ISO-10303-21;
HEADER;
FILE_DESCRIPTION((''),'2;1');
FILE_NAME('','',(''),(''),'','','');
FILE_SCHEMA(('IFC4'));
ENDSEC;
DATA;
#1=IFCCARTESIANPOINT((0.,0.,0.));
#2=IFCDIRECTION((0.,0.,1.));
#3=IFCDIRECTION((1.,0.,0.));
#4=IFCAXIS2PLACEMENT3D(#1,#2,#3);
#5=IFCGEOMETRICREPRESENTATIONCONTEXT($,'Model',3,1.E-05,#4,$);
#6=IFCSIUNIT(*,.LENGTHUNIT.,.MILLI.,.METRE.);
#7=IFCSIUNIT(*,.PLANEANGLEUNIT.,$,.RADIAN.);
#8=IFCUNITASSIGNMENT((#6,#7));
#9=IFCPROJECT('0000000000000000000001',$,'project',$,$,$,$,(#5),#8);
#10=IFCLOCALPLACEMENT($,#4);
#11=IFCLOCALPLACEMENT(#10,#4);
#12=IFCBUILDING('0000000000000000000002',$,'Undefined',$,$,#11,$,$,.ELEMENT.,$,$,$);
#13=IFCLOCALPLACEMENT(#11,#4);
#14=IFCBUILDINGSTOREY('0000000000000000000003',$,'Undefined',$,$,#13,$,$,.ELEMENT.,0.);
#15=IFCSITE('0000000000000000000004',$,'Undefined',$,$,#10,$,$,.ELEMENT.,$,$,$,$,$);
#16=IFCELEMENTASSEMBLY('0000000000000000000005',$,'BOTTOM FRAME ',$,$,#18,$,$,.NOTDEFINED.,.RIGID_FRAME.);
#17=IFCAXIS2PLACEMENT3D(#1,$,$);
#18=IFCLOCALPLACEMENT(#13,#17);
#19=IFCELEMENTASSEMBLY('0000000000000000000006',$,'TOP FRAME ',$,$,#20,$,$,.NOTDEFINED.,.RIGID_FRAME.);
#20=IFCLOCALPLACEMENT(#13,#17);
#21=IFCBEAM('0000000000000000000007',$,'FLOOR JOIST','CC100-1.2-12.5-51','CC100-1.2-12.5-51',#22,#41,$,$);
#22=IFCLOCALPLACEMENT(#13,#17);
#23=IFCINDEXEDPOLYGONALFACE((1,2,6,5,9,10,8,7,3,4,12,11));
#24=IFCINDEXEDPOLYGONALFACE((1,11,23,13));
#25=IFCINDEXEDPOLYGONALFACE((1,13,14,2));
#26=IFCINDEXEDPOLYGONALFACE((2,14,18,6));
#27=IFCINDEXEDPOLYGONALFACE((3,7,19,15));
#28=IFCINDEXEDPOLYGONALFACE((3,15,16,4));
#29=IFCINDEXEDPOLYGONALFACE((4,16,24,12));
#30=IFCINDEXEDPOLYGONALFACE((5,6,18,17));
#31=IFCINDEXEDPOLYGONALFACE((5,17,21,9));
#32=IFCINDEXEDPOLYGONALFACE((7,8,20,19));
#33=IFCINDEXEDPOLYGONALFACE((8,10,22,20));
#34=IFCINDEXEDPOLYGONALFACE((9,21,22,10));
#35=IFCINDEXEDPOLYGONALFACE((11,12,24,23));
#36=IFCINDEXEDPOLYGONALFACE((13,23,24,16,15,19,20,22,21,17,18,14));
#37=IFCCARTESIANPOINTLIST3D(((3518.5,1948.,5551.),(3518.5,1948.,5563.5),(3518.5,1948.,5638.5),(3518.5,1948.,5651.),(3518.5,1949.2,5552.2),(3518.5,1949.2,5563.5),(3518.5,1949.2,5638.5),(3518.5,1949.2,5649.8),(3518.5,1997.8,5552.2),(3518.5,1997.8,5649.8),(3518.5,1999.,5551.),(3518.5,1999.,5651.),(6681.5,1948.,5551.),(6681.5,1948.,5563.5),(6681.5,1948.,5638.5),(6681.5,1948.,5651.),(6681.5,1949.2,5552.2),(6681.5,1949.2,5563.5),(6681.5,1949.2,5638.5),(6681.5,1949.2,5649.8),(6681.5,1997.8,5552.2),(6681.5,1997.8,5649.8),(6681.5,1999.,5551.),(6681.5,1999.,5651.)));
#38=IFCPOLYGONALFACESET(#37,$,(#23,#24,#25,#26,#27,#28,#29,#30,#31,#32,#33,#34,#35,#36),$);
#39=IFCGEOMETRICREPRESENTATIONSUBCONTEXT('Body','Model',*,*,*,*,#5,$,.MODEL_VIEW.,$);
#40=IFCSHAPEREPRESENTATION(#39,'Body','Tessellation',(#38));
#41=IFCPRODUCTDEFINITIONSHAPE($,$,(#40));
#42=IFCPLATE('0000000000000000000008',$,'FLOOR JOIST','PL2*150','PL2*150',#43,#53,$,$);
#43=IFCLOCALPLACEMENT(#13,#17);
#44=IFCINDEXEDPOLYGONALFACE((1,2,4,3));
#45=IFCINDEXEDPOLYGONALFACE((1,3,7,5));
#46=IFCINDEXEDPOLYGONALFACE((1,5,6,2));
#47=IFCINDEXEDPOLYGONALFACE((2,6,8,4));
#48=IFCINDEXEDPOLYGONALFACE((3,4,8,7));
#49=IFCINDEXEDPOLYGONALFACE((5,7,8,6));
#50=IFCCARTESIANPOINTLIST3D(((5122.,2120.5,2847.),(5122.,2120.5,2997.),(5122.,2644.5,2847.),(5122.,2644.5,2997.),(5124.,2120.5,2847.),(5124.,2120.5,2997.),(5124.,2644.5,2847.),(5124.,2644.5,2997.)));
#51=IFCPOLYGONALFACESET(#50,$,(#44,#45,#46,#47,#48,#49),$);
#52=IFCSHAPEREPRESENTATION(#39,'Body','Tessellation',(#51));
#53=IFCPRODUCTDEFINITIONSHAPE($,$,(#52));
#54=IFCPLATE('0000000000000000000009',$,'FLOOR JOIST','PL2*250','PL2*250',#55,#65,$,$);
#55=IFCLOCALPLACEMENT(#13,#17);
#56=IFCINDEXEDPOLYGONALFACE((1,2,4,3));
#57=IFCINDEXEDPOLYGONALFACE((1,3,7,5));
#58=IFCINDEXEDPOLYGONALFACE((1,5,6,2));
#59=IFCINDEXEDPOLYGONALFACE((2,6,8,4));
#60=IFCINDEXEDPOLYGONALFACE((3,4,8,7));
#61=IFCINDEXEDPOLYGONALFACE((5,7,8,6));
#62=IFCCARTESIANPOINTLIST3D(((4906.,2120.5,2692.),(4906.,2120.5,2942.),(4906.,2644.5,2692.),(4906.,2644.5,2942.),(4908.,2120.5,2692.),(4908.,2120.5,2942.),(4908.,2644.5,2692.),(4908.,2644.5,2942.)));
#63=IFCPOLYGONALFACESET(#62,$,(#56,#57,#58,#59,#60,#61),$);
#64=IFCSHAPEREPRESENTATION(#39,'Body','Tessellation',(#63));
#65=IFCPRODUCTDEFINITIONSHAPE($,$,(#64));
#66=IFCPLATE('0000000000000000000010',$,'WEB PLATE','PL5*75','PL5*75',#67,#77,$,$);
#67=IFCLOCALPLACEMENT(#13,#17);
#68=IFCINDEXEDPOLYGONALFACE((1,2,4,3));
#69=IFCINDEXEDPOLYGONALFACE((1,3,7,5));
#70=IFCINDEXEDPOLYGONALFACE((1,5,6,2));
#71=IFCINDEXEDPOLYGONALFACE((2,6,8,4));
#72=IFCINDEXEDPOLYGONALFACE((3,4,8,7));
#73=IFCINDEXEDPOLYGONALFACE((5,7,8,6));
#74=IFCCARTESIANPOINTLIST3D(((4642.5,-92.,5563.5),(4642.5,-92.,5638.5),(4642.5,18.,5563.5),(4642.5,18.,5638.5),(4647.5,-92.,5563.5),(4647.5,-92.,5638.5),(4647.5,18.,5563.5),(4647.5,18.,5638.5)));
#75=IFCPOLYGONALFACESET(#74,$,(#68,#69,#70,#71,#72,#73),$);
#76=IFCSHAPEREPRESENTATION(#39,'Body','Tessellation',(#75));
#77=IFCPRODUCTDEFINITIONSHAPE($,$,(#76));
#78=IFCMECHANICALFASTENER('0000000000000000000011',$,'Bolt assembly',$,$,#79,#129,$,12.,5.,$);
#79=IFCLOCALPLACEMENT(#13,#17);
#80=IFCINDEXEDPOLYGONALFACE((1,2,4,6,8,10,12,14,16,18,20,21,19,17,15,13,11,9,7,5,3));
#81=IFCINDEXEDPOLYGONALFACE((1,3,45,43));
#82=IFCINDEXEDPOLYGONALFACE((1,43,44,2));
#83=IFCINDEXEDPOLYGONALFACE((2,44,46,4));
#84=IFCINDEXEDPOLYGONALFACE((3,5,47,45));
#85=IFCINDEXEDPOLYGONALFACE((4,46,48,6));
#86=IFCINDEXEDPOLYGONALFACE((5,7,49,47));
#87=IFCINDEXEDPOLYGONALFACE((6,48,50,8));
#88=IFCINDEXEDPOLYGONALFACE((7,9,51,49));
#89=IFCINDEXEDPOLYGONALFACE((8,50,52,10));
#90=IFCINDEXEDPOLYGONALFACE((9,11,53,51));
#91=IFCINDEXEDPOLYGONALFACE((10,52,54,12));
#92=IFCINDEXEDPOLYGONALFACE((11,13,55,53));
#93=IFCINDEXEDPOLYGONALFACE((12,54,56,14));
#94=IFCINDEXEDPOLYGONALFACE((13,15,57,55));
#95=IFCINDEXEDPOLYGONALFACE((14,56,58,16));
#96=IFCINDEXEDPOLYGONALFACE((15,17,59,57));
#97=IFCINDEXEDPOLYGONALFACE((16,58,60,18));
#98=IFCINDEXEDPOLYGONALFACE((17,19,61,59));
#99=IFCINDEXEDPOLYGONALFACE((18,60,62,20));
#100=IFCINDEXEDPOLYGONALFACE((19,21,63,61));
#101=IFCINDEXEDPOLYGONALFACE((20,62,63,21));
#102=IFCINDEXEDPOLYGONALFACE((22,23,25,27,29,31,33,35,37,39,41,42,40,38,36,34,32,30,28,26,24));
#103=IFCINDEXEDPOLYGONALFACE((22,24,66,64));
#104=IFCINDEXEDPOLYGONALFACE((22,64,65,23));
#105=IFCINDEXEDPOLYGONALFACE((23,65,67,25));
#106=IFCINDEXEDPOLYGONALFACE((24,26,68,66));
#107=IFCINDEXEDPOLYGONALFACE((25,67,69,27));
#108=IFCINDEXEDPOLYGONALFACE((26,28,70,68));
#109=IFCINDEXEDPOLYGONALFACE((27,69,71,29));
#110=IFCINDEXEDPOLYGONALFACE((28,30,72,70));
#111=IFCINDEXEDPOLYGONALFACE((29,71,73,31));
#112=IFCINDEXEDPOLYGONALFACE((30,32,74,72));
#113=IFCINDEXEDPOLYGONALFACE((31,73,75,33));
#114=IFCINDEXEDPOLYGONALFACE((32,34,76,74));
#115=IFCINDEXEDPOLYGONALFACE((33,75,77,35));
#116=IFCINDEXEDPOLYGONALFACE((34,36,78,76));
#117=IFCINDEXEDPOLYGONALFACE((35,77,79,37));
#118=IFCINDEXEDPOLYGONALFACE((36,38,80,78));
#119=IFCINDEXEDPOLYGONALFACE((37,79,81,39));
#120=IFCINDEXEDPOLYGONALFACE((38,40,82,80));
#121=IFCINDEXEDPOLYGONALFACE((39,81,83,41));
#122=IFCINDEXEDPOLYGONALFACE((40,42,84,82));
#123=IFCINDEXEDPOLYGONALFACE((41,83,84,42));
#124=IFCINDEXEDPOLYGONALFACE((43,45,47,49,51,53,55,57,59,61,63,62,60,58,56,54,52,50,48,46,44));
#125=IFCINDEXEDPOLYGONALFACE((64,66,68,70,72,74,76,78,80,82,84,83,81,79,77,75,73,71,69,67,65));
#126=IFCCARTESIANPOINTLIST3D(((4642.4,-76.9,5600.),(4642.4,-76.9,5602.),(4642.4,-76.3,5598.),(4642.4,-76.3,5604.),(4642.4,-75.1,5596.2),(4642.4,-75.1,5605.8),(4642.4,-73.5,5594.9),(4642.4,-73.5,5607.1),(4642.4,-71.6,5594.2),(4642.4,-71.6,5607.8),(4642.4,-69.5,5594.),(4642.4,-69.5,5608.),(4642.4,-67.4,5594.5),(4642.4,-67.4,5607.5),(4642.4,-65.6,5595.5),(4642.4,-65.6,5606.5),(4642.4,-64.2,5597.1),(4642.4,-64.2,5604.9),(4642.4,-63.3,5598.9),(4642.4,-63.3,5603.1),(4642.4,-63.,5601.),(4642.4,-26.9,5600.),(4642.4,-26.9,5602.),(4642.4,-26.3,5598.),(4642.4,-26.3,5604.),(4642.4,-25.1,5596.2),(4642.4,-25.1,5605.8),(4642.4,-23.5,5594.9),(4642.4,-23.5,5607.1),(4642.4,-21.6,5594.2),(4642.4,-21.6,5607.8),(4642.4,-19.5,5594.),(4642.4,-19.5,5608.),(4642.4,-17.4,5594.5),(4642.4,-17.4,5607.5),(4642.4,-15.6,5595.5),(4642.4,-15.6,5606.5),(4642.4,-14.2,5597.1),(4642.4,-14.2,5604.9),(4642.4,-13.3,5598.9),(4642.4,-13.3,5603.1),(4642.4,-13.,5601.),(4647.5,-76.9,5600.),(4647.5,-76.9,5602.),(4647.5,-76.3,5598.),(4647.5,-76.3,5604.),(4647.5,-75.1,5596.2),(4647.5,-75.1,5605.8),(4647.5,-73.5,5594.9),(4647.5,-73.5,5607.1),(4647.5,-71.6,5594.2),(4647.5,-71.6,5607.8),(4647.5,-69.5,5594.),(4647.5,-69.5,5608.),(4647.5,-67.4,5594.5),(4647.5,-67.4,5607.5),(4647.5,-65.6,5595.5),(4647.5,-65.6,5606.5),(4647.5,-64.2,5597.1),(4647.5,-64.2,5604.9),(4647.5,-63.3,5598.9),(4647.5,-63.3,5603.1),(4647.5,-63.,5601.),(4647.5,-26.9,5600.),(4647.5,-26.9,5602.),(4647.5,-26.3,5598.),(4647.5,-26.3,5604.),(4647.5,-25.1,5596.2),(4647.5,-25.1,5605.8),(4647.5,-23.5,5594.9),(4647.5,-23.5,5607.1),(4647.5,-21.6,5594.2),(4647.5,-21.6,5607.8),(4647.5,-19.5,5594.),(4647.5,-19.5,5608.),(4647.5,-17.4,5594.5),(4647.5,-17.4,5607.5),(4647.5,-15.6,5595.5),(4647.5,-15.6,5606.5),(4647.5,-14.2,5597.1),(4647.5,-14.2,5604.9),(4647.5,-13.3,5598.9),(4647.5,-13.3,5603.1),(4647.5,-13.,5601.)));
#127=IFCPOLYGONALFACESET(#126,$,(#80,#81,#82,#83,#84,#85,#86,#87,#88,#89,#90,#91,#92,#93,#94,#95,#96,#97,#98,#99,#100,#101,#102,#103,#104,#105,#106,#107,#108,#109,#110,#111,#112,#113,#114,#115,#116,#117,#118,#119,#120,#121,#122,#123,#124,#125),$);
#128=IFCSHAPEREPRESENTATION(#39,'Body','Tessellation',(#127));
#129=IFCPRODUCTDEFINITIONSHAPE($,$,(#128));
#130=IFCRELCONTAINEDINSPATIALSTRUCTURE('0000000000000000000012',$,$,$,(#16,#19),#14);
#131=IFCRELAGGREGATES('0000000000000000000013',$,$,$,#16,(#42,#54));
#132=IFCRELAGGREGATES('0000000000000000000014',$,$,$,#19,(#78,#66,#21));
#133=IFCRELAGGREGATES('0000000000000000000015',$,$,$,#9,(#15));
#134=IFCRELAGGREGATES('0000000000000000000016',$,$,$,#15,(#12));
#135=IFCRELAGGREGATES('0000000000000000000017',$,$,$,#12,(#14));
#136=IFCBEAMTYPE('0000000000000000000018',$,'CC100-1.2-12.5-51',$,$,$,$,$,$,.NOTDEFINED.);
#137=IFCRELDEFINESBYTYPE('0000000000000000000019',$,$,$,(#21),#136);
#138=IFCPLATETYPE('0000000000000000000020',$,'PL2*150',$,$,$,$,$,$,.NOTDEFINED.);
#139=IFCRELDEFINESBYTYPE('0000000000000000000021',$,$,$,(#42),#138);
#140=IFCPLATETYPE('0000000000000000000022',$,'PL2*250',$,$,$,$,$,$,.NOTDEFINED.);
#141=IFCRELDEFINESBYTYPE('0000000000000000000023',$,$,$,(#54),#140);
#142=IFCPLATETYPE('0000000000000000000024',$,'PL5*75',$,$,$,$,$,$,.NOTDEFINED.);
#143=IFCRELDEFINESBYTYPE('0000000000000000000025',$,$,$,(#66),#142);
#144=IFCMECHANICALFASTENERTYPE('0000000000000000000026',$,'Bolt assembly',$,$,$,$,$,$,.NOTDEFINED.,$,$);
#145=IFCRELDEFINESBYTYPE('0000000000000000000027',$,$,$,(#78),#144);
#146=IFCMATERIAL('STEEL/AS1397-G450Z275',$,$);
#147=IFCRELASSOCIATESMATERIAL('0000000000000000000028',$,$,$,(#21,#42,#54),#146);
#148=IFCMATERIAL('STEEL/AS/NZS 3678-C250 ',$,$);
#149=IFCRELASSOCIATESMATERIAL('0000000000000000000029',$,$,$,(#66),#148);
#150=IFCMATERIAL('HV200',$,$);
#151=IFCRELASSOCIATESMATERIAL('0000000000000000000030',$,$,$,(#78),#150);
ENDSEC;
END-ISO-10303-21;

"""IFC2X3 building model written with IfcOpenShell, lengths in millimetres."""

from ifc_helpers import new_model, si_unit, frame, origin_with_axes, origin_2d_with_axis, place, context, subcontext, project, spatial, polyline, circle, c_section, outline, extrude, source, transform, mapped, material, type_object, element, aggregate, save


model = new_model("IFC2X3")

# Units and contexts
model_context = context("Model", 3, precision=1e-05, world=origin_with_axes())
body_context = subcontext(model_context, "Body", "Model", "MODEL_VIEW")
ifc_project = project(units=[si_unit("LENGTHUNIT", "METRE", prefix="MILLI"), si_unit("PLANEANGLEUNIT", "RADIAN")], contexts=[model_context])

# Site, building, storey
site_placement = place(None, origin_with_axes())
site = spatial("IfcSite", under=ifc_project, at=site_placement, Name="Undefined", CompositionType="ELEMENT")
building_placement = place(site_placement, origin_with_axes())
building = spatial("IfcBuilding", under=site, at=building_placement, Name="Undefined", CompositionType="ELEMENT")
storey_placement = place(building_placement, origin_with_axes())
storey = spatial("IfcBuildingStorey", under=building, at=storey_placement, Name="Undefined", CompositionType="ELEMENT", Elevation=0.0)

# Element assemblies, beam
assembly_1_placement = place(storey_placement, origin_with_axes())
assembly_1 = element("IfcElementAssembly", 1, at=assembly_1_placement, inside=storey, Name="BOTTOM FRAME ", AssemblyPlace="NOTDEFINED", PredefinedType="RIGID_FRAME")
ifc_material_1 = material(Name="STEEL/AS1397-G450Z275")
assembly_2_placement = place(storey_placement, origin_with_axes())
assembly_2 = element("IfcElementAssembly", 2, at=assembly_2_placement, inside=storey, Name="TOP FRAME ", AssemblyPlace="NOTDEFINED", PredefinedType="RIGID_FRAME")
beam_type_1 = type_object("IfcBeamType", Name="CC100-1.2-12.5-51", PredefinedType="NOTDEFINED")
beam_1_placement = place(assembly_2_placement, frame((3518.5, 1973.5, 5601.0), z_axis=(0.0, 0.0, 1.0), x_axis=(1.0, 0.0, 0.0)))
beam_1 = element("IfcBeam", 3, at=beam_1_placement, type_object=beam_type_1, material=ifc_material_1, Name="FLOOR JOIST", Description="CC100-1.2-12.5-51", ObjectType="CC100-1.2-12.5-51", context=body_context, shape_type="SweptSolid", body=[
    extrude(c_section(Depth=100.0, Width=51.0, WallThickness=1.2, Girth=12.5, at=origin_2d_with_axis()), frame((3163.0, 0.0, 0.0), z_axis=(-1.0, 0.0, 0.0), x_axis=(0.0, -1.0, 0.0)), (0.0, 0.0, 1.0), 3163.0),
])

# Plates
ifc_material_2 = material(Name="STEEL/AS/NZS 3678-C250 ")
plate_type_1 = type_object("IfcPlateType", Name="PL2*150", PredefinedType="NOTDEFINED")
plate_1_placement = place(assembly_1_placement, frame((5123.0, 2644.5, 2922.0), z_axis=(1.0, 0.0, 0.0), x_axis=(0.0, -1.0, 0.0)))
plate_1 = element("IfcPlate", 4, at=plate_1_placement, type_object=plate_type_1, material=ifc_material_1, Name="FLOOR JOIST", Description="PL2*150", ObjectType="PL2*150", context=body_context, shape_type="SweptSolid", body=[
    extrude(outline(polyline([(524.0, 75.0), (524.0, -75.0), (0.0, -75.0), (0.0, 75.0), (524.0, 75.0)])), frame((0.0, 0.0, -1.0), z_axis=(0.0, 0.0, 1.0), x_axis=(1.0, 0.0, 0.0)), (0.0, 0.0, 1.0), 2.0),
])
plate_type_2 = type_object("IfcPlateType", Name="PL2*250", PredefinedType="NOTDEFINED")
plate_2_placement = place(assembly_1_placement, frame((4907.0, 2644.5, 2817.0), z_axis=(1.0, 0.0, 0.0), x_axis=(0.0, -1.0, 0.0)))
plate_2 = element("IfcPlate", 5, at=plate_2_placement, type_object=plate_type_2, material=ifc_material_1, Name="FLOOR JOIST", Description="PL2*250", ObjectType="PL2*250", context=body_context, shape_type="SweptSolid", body=[
    extrude(outline(polyline([(524.0, 125.0), (524.0, -125.0), (0.0, -125.0), (0.0, 125.0), (524.0, 125.0)])), frame((0.0, 0.0, -1.0), z_axis=(0.0, 0.0, 1.0), x_axis=(1.0, 0.0, 0.0)), (0.0, 0.0, 1.0), 2.0),
])
aggregate(assembly_1, [plate_1, plate_2])
plate_type_3 = type_object("IfcPlateType", Name="PL5*75", PredefinedType="NOTDEFINED")
plate_3_placement = place(assembly_2_placement, frame((4645.0, 18.0, 5601.0), z_axis=(1.0, 0.0, 0.0), x_axis=(0.0, -1.0, 0.0)))
plate_3 = element("IfcPlate", 6, at=plate_3_placement, type_object=plate_type_3, material=ifc_material_2, Name="WEB PLATE", Description="PL5*75", ObjectType="PL5*75", context=body_context, shape_type="SweptSolid", body=[
    extrude(outline(polyline([(110.0, 37.5), (110.0, -37.5), (0.0, -37.5), (0.0, 37.5), (110.0, 37.5)])), frame((0.0, 0.0, -2.5), z_axis=(0.0, 0.0, 1.0), x_axis=(1.0, 0.0, 0.0)), (0.0, 0.0, 1.0), 5.0),
])

# Mechanical fastener
ifc_material_3 = material(Name="HV200")
mechanical_fastener_type = type_object("IfcMechanicalFastenerType", Name="Bolt assembly")
shared_shape = source(origin_with_axes(), body_context, "Body", "SweptSolid", [
    extrude(circle(Radius=7.0, at=origin_2d_with_axis()), frame((0.0, 0.0, 0.0), z_axis=(0.0, 1.0, 0.0), x_axis=(1.0, 0.0, 0.0)), (0.0, 0.0, 1.0), 5.1),
])
mechanical_fastener_placement = place(assembly_2_placement, frame((4647.5, -70.0, 5601.0), z_axis=(0.0, 0.0, 1.0), x_axis=(0.000002, 1.0, 0.0)))
mechanical_fastener = element("IfcMechanicalFastener", 7, at=mechanical_fastener_placement, type_object=mechanical_fastener_type, material=ifc_material_3, Name="Bolt assembly", NominalDiameter=12.0, NominalLength=5.0, context=body_context, shape_type="MappedRepresentation", body=[
    mapped(shared_shape, transform((0.0, 0.0, 0.0))),
    mapped(shared_shape, transform((50.0, 0.0, 0.0))),
])
aggregate(assembly_2, [mechanical_fastener, plate_3, beam_1])

save(model, "model.ifc")
